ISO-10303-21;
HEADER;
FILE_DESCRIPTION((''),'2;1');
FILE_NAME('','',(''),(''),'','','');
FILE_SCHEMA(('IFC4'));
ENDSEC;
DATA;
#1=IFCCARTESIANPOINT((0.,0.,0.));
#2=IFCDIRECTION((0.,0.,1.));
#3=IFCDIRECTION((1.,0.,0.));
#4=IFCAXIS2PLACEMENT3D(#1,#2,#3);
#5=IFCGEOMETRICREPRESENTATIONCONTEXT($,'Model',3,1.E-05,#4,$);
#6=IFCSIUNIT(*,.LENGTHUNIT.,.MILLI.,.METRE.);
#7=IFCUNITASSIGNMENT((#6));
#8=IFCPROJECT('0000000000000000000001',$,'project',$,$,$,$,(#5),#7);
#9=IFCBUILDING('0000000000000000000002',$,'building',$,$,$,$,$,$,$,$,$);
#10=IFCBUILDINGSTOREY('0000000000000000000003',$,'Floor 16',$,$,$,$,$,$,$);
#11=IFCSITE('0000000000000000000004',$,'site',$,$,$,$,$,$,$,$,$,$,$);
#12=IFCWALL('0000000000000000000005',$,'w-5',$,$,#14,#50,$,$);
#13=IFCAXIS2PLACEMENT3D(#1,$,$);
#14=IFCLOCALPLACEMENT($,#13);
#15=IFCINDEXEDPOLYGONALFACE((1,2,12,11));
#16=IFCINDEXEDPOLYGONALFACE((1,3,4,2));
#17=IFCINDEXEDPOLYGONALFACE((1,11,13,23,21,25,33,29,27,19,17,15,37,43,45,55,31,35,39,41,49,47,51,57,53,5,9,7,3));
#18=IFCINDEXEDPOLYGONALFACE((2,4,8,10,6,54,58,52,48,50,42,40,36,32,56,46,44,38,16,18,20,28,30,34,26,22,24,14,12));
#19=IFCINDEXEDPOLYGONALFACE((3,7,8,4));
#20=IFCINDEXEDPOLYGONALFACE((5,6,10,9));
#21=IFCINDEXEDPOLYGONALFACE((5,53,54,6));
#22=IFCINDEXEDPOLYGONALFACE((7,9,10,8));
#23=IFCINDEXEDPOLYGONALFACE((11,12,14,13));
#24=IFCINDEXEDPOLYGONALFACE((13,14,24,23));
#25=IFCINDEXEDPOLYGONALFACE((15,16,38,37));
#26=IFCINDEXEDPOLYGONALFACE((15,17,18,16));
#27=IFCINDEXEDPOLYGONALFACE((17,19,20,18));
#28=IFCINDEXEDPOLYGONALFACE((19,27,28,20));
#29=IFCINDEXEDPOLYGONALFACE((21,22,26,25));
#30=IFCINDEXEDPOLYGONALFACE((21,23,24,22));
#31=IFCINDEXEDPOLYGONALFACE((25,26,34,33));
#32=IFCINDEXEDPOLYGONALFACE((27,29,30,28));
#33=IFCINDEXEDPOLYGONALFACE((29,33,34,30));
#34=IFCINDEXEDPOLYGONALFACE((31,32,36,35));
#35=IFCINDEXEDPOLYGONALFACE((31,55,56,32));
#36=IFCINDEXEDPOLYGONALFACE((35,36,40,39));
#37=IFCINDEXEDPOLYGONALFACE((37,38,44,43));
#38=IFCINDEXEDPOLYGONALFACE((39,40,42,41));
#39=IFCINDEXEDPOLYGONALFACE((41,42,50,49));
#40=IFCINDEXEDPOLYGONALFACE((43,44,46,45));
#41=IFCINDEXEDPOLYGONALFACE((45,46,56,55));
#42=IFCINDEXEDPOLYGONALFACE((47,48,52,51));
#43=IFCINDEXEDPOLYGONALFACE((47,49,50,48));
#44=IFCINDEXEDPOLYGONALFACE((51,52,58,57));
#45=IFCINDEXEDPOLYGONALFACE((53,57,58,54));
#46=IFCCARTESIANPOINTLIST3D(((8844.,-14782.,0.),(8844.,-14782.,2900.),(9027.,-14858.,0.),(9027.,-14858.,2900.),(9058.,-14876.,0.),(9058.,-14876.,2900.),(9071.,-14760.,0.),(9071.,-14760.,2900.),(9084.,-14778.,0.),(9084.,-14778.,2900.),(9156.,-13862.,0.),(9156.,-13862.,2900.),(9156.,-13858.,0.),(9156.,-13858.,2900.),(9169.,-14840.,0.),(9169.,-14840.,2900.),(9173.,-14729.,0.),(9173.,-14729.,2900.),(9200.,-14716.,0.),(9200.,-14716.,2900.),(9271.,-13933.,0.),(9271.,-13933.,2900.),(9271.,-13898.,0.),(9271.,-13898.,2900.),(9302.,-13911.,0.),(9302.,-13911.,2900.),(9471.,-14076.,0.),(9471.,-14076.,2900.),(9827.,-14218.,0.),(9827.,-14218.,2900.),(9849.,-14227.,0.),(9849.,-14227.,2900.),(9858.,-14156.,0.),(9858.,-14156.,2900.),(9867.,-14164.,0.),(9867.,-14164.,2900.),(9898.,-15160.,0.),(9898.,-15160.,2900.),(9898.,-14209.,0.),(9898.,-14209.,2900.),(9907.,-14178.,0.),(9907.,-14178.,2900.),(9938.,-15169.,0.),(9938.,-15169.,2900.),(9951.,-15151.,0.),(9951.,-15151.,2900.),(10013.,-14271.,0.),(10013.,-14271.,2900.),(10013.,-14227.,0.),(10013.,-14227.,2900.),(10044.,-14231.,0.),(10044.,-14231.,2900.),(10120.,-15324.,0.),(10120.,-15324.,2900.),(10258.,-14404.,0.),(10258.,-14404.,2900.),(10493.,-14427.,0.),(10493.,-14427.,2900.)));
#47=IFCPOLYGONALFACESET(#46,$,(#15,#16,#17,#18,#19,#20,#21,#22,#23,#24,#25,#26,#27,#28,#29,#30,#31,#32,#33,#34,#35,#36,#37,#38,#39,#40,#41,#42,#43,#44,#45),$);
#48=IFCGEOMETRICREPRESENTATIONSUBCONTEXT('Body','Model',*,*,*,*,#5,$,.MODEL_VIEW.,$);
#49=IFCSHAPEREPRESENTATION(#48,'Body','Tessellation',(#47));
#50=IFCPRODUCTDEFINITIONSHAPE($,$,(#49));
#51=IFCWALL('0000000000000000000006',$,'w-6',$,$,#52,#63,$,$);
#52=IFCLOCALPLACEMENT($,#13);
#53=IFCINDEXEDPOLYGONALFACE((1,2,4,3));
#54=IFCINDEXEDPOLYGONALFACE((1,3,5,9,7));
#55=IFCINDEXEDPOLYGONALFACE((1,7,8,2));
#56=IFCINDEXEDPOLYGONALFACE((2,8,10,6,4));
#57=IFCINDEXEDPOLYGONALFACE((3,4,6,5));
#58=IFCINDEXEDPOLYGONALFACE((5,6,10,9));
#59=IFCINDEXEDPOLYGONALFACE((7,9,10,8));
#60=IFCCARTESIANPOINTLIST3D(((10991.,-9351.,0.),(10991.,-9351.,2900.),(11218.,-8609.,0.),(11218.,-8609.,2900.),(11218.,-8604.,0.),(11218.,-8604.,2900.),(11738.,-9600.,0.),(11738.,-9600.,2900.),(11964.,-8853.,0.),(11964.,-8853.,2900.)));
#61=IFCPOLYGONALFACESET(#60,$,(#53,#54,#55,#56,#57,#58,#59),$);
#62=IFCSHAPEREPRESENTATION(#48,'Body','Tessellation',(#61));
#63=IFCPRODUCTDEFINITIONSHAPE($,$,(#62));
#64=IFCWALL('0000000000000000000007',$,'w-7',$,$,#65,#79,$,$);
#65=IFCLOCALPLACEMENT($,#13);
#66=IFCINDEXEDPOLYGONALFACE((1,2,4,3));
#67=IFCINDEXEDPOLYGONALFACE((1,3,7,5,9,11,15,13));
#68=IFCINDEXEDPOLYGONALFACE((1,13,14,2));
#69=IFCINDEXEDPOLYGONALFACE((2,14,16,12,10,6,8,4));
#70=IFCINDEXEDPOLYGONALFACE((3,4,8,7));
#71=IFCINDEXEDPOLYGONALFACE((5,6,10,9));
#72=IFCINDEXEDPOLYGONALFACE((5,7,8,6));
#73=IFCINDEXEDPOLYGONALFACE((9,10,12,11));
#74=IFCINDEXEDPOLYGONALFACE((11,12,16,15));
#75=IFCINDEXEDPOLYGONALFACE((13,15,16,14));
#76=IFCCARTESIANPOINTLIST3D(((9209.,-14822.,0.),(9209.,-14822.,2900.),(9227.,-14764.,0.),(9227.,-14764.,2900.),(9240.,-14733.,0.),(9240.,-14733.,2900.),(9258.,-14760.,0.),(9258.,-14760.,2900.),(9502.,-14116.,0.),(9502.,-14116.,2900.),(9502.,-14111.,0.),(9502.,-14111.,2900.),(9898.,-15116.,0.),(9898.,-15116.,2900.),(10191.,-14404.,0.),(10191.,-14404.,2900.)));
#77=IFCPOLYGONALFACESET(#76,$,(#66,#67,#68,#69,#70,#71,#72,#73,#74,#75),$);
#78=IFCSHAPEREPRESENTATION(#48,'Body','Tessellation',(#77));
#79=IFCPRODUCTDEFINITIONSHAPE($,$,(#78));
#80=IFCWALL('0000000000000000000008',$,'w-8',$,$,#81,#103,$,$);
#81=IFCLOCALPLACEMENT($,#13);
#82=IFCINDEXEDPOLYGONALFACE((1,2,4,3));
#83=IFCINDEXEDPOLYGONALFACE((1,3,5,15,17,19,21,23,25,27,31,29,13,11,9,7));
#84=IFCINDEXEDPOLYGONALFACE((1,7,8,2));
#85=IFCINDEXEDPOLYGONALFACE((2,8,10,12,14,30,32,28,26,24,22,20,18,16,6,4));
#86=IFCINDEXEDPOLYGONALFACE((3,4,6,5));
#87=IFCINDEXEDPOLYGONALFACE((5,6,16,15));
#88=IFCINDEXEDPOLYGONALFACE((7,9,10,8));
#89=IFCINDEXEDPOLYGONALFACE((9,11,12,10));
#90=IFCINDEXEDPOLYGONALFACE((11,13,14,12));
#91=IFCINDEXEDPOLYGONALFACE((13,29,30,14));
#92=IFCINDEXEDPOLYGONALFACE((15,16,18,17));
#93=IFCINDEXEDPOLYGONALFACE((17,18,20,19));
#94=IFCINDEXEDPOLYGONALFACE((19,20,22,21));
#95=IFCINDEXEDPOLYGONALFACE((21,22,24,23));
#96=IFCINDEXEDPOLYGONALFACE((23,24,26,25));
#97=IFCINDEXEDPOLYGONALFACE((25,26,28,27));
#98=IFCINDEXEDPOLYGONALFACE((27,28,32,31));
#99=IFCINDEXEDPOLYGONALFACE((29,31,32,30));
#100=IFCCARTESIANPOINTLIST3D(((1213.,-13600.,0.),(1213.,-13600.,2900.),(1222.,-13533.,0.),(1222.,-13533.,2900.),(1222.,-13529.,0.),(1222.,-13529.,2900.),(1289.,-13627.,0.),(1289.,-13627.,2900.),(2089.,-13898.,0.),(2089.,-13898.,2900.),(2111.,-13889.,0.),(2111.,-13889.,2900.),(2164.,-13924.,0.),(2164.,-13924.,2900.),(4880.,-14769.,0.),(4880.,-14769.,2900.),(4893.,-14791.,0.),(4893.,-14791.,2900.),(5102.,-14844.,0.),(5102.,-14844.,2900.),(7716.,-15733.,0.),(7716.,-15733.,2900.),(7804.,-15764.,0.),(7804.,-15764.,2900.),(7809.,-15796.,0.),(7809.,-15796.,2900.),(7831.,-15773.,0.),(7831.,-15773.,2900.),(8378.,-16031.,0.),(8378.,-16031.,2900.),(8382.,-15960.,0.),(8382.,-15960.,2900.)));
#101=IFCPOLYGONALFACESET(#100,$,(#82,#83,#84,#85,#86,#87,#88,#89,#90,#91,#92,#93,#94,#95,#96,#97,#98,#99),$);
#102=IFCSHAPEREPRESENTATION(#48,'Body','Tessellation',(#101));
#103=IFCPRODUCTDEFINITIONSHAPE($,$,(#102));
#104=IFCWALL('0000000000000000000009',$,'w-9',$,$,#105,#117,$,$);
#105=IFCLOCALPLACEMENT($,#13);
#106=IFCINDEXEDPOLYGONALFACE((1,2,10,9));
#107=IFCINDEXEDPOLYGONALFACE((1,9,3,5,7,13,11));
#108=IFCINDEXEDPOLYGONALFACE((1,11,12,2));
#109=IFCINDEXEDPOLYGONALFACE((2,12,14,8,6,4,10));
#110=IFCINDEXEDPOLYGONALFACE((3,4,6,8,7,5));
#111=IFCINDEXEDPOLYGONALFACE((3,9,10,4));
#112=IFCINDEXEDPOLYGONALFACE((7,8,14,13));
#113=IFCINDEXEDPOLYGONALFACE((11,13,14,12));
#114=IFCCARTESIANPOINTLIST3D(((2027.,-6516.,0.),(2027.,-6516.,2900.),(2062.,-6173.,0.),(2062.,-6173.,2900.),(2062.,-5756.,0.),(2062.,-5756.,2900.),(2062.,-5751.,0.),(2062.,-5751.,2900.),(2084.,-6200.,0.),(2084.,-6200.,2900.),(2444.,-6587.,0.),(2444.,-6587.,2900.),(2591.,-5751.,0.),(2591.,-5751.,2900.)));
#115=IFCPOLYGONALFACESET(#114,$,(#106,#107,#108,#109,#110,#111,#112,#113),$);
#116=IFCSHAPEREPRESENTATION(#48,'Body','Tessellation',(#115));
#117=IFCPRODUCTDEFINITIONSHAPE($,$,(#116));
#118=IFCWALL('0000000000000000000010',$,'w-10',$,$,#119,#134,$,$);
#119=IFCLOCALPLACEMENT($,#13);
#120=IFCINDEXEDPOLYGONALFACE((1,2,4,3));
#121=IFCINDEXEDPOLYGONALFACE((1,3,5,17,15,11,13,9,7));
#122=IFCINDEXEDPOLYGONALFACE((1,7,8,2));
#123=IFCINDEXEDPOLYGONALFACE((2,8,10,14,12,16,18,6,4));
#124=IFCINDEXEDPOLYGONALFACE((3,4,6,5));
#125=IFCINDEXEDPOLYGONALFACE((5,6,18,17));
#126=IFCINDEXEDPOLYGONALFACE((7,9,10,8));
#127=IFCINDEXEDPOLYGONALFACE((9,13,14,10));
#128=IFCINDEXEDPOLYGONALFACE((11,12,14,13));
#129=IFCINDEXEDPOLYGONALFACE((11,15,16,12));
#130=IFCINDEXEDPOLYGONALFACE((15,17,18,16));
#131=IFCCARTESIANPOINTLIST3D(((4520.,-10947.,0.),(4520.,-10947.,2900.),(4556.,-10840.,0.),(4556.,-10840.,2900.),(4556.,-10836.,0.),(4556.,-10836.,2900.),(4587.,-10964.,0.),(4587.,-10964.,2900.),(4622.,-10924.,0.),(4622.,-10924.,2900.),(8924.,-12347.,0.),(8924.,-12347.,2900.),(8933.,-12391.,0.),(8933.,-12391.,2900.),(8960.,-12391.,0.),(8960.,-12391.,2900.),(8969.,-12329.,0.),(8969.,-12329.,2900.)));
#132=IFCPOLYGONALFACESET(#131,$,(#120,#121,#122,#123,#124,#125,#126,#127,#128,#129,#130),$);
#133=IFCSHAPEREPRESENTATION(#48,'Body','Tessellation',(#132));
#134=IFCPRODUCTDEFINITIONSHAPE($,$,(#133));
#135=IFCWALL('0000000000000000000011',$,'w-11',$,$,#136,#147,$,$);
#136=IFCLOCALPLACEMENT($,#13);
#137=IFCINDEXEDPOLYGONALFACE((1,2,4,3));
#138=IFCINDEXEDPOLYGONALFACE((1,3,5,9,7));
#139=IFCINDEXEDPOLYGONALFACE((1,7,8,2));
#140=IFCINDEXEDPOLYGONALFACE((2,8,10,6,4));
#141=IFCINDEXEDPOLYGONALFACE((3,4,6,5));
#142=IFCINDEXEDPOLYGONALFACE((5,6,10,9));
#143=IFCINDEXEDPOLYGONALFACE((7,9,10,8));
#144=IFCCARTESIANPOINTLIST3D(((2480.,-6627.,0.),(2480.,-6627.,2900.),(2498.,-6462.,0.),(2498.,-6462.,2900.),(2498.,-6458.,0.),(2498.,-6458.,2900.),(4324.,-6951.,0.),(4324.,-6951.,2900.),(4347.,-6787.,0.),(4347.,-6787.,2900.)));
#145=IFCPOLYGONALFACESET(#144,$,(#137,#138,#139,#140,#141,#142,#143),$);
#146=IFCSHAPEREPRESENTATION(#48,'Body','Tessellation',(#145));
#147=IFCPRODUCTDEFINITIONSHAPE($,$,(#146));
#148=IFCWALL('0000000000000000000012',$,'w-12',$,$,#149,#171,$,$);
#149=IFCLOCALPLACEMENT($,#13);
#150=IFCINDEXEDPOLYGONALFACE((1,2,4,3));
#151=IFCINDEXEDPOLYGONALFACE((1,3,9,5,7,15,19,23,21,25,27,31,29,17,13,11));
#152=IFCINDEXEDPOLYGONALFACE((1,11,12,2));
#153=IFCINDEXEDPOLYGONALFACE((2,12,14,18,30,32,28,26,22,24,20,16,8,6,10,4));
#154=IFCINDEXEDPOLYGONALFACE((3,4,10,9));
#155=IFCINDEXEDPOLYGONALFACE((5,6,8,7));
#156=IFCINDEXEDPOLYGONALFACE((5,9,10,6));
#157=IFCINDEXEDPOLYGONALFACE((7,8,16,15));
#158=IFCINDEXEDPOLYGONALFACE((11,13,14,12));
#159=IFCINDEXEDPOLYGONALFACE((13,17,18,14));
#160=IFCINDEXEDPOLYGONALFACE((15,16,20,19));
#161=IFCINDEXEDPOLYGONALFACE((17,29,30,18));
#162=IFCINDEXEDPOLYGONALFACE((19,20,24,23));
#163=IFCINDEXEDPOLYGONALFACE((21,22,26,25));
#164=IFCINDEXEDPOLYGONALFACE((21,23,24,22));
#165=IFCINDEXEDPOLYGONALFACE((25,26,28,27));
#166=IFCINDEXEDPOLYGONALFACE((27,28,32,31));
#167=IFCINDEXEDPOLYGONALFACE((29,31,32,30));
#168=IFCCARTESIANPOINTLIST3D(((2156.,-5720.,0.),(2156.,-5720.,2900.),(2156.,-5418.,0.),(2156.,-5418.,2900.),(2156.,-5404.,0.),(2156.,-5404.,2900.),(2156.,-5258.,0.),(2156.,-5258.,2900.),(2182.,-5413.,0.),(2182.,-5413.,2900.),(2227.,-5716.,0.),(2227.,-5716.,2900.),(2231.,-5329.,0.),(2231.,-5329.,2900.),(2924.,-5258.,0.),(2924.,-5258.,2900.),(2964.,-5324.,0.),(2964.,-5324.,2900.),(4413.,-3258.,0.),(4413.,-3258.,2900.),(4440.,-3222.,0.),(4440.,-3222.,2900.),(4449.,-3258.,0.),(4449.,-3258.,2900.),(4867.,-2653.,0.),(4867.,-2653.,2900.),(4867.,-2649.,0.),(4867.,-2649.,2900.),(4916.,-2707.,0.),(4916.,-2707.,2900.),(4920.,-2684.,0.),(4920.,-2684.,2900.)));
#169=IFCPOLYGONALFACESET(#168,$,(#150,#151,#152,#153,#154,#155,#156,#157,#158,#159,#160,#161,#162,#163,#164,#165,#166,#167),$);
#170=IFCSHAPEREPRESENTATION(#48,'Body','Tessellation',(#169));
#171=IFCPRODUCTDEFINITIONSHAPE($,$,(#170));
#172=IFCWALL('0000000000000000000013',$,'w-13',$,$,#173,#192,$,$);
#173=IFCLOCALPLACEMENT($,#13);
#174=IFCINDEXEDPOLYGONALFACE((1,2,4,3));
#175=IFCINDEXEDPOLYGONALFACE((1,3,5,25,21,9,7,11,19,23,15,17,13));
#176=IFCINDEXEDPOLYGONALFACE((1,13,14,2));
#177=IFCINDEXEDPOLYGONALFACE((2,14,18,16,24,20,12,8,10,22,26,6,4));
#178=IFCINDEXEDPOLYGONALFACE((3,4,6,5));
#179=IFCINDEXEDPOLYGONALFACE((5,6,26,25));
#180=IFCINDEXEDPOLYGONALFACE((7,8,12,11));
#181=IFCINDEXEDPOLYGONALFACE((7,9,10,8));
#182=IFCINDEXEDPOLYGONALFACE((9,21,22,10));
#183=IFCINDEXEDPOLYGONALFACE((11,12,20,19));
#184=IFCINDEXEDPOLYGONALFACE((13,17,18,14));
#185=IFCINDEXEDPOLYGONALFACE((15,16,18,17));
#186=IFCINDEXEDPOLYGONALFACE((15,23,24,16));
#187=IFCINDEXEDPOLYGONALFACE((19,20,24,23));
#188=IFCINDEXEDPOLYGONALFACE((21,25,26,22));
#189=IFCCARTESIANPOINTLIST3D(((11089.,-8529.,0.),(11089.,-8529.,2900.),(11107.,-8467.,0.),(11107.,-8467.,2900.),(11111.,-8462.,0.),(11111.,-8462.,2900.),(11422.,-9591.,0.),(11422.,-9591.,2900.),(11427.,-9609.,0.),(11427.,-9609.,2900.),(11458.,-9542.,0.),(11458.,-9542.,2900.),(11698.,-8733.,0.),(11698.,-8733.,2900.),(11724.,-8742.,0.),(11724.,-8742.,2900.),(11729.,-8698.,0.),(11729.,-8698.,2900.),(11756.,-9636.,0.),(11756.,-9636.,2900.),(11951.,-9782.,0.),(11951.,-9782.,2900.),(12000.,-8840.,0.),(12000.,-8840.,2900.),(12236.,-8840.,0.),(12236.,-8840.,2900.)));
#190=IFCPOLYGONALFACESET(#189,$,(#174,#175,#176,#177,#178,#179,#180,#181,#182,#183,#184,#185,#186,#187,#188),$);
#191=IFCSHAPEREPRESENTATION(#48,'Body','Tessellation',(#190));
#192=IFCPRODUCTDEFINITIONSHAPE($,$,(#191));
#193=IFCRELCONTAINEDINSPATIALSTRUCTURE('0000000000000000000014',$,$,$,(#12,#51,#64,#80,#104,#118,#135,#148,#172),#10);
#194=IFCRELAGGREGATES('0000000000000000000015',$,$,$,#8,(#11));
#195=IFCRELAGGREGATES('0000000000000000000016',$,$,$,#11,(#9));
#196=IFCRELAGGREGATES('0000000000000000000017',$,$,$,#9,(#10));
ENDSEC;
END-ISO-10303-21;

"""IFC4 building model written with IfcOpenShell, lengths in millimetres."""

from ifc_helpers import new_model, si_unit, origin_with_axes, place, context, subcontext, project, spatial, indexed_curve, outline, extrude, element, save


model = new_model("IFC4")

# Units and contexts
model_context = context("Model", 3, precision=1e-05, world=origin_with_axes())
body_context = subcontext(model_context, "Body", "Model", "MODEL_VIEW")
ifc_project = project(units=[si_unit("LENGTHUNIT", "METRE", prefix="MILLI")], contexts=[model_context])

# Site, building, storey
site = spatial("IfcSite", under=ifc_project, Name="site")
building = spatial("IfcBuilding", under=site, Name="building")
storey = spatial("IfcBuildingStorey", under=building, Name="Floor 16")

# Walls
wall_1_placement = place(None, origin_with_axes())
element("IfcWall", 1, at=wall_1_placement, inside=storey, Name="w-5", context=body_context, shape_type="SweptSolid", body=[
    extrude(outline(indexed_curve([(9156.0, -13858.0), (9156.0, -13862.0), (8844.0, -14782.0), (9027.0, -14858.0), (9071.0, -14760.0), (9084.0, -14778.0), (9058.0, -14876.0), (10120.0, -15324.0), (10493.0, -14427.0), (10044.0, -14231.0), (10013.0, -14271.0), (10013.0, -14227.0), (9907.0, -14178.0), (9898.0, -14209.0), (9867.0, -14164.0), (9849.0, -14227.0), (10258.0, -14404.0), (9951.0, -15151.0), (9938.0, -15169.0), (9898.0, -15160.0), (9169.0, -14840.0), (9173.0, -14729.0), (9200.0, -14716.0), (9471.0, -14076.0), (9827.0, -14218.0), (9858.0, -14156.0), (9302.0, -13911.0), (9271.0, -13933.0), (9271.0, -13898.0)])), None, (0.0, 0.0, 1.0), 2900.0),
])
wall_2_placement = place(None, origin_with_axes())
element("IfcWall", 2, at=wall_2_placement, inside=storey, Name="w-6", context=body_context, shape_type="SweptSolid", body=[
    extrude(outline(indexed_curve([(11218.0, -8604.0), (11218.0, -8609.0), (10991.0, -9351.0), (11738.0, -9600.0), (11964.0, -8853.0)])), None, (0.0, 0.0, 1.0), 2900.0),
])
wall_3_placement = place(None, origin_with_axes())
element("IfcWall", 3, at=wall_3_placement, inside=storey, Name="w-7", context=body_context, shape_type="SweptSolid", body=[
    extrude(outline(indexed_curve([(9502.0, -14111.0), (9502.0, -14116.0), (9240.0, -14733.0), (9258.0, -14760.0), (9227.0, -14764.0), (9209.0, -14822.0), (9898.0, -15116.0), (10191.0, -14404.0)])), None, (0.0, 0.0, 1.0), 2900.0),
])
wall_4_placement = place(None, origin_with_axes())
element("IfcWall", 4, at=wall_4_placement, inside=storey, Name="w-8", context=body_context, shape_type="SweptSolid", body=[
    extrude(outline(indexed_curve([(1222.0, -13529.0), (1222.0, -13533.0), (1213.0, -13600.0), (1289.0, -13627.0), (2089.0, -13898.0), (2111.0, -13889.0), (2164.0, -13924.0), (8378.0, -16031.0), (8382.0, -15960.0), (7831.0, -15773.0), (7809.0, -15796.0), (7804.0, -15764.0), (7716.0, -15733.0), (5102.0, -14844.0), (4893.0, -14791.0), (4880.0, -14769.0)])), None, (0.0, 0.0, 1.0), 2900.0),
])
wall_5_placement = place(None, origin_with_axes())
element("IfcWall", 5, at=wall_5_placement, inside=storey, Name="w-9", context=body_context, shape_type="SweptSolid", body=[
    extrude(outline(indexed_curve([(2062.0, -5751.0), (2062.0, -5756.0), (2062.0, -6173.0), (2084.0, -6200.0), (2027.0, -6516.0), (2444.0, -6587.0), (2591.0, -5751.0)])), None, (0.0, 0.0, 1.0), 2900.0),
])
wall_6_placement = place(None, origin_with_axes())
element("IfcWall", 6, at=wall_6_placement, inside=storey, Name="w-10", context=body_context, shape_type="SweptSolid", body=[
    extrude(outline(indexed_curve([(4556.0, -10836.0), (4556.0, -10840.0), (4520.0, -10947.0), (4587.0, -10964.0), (4622.0, -10924.0), (8933.0, -12391.0), (8924.0, -12347.0), (8960.0, -12391.0), (8969.0, -12329.0)])), None, (0.0, 0.0, 1.0), 2900.0),
])
wall_7_placement = place(None, origin_with_axes())
element("IfcWall", 7, at=wall_7_placement, inside=storey, Name="w-11", context=body_context, shape_type="SweptSolid", body=[
    extrude(outline(indexed_curve([(2498.0, -6458.0), (2498.0, -6462.0), (2480.0, -6627.0), (4324.0, -6951.0), (4347.0, -6787.0)])), None, (0.0, 0.0, 1.0), 2900.0),
])
wall_8_placement = place(None, origin_with_axes())
element("IfcWall", 8, at=wall_8_placement, inside=storey, Name="w-12", context=body_context, shape_type="SweptSolid", body=[
    extrude(outline(indexed_curve([(4867.0, -2649.0), (4867.0, -2653.0), (4440.0, -3222.0), (4449.0, -3258.0), (4413.0, -3258.0), (2924.0, -5258.0), (2156.0, -5258.0), (2156.0, -5404.0), (2182.0, -5413.0), (2156.0, -5418.0), (2156.0, -5720.0), (2227.0, -5716.0), (2231.0, -5329.0), (2964.0, -5324.0), (4916.0, -2707.0), (4920.0, -2684.0)])), None, (0.0, 0.0, 1.0), 2900.0),
])
wall_9_placement = place(None, origin_with_axes())
element("IfcWall", 9, at=wall_9_placement, inside=storey, Name="w-13", context=body_context, shape_type="SweptSolid", body=[
    extrude(outline(indexed_curve([(11111.0, -8462.0), (11107.0, -8467.0), (11089.0, -8529.0), (11698.0, -8733.0), (11729.0, -8698.0), (11724.0, -8742.0), (12000.0, -8840.0), (11756.0, -9636.0), (11458.0, -9542.0), (11422.0, -9591.0), (11427.0, -9609.0), (11951.0, -9782.0), (12236.0, -8840.0)])), None, (0.0, 0.0, 1.0), 2900.0),
])

save(model, "model.ifc")
